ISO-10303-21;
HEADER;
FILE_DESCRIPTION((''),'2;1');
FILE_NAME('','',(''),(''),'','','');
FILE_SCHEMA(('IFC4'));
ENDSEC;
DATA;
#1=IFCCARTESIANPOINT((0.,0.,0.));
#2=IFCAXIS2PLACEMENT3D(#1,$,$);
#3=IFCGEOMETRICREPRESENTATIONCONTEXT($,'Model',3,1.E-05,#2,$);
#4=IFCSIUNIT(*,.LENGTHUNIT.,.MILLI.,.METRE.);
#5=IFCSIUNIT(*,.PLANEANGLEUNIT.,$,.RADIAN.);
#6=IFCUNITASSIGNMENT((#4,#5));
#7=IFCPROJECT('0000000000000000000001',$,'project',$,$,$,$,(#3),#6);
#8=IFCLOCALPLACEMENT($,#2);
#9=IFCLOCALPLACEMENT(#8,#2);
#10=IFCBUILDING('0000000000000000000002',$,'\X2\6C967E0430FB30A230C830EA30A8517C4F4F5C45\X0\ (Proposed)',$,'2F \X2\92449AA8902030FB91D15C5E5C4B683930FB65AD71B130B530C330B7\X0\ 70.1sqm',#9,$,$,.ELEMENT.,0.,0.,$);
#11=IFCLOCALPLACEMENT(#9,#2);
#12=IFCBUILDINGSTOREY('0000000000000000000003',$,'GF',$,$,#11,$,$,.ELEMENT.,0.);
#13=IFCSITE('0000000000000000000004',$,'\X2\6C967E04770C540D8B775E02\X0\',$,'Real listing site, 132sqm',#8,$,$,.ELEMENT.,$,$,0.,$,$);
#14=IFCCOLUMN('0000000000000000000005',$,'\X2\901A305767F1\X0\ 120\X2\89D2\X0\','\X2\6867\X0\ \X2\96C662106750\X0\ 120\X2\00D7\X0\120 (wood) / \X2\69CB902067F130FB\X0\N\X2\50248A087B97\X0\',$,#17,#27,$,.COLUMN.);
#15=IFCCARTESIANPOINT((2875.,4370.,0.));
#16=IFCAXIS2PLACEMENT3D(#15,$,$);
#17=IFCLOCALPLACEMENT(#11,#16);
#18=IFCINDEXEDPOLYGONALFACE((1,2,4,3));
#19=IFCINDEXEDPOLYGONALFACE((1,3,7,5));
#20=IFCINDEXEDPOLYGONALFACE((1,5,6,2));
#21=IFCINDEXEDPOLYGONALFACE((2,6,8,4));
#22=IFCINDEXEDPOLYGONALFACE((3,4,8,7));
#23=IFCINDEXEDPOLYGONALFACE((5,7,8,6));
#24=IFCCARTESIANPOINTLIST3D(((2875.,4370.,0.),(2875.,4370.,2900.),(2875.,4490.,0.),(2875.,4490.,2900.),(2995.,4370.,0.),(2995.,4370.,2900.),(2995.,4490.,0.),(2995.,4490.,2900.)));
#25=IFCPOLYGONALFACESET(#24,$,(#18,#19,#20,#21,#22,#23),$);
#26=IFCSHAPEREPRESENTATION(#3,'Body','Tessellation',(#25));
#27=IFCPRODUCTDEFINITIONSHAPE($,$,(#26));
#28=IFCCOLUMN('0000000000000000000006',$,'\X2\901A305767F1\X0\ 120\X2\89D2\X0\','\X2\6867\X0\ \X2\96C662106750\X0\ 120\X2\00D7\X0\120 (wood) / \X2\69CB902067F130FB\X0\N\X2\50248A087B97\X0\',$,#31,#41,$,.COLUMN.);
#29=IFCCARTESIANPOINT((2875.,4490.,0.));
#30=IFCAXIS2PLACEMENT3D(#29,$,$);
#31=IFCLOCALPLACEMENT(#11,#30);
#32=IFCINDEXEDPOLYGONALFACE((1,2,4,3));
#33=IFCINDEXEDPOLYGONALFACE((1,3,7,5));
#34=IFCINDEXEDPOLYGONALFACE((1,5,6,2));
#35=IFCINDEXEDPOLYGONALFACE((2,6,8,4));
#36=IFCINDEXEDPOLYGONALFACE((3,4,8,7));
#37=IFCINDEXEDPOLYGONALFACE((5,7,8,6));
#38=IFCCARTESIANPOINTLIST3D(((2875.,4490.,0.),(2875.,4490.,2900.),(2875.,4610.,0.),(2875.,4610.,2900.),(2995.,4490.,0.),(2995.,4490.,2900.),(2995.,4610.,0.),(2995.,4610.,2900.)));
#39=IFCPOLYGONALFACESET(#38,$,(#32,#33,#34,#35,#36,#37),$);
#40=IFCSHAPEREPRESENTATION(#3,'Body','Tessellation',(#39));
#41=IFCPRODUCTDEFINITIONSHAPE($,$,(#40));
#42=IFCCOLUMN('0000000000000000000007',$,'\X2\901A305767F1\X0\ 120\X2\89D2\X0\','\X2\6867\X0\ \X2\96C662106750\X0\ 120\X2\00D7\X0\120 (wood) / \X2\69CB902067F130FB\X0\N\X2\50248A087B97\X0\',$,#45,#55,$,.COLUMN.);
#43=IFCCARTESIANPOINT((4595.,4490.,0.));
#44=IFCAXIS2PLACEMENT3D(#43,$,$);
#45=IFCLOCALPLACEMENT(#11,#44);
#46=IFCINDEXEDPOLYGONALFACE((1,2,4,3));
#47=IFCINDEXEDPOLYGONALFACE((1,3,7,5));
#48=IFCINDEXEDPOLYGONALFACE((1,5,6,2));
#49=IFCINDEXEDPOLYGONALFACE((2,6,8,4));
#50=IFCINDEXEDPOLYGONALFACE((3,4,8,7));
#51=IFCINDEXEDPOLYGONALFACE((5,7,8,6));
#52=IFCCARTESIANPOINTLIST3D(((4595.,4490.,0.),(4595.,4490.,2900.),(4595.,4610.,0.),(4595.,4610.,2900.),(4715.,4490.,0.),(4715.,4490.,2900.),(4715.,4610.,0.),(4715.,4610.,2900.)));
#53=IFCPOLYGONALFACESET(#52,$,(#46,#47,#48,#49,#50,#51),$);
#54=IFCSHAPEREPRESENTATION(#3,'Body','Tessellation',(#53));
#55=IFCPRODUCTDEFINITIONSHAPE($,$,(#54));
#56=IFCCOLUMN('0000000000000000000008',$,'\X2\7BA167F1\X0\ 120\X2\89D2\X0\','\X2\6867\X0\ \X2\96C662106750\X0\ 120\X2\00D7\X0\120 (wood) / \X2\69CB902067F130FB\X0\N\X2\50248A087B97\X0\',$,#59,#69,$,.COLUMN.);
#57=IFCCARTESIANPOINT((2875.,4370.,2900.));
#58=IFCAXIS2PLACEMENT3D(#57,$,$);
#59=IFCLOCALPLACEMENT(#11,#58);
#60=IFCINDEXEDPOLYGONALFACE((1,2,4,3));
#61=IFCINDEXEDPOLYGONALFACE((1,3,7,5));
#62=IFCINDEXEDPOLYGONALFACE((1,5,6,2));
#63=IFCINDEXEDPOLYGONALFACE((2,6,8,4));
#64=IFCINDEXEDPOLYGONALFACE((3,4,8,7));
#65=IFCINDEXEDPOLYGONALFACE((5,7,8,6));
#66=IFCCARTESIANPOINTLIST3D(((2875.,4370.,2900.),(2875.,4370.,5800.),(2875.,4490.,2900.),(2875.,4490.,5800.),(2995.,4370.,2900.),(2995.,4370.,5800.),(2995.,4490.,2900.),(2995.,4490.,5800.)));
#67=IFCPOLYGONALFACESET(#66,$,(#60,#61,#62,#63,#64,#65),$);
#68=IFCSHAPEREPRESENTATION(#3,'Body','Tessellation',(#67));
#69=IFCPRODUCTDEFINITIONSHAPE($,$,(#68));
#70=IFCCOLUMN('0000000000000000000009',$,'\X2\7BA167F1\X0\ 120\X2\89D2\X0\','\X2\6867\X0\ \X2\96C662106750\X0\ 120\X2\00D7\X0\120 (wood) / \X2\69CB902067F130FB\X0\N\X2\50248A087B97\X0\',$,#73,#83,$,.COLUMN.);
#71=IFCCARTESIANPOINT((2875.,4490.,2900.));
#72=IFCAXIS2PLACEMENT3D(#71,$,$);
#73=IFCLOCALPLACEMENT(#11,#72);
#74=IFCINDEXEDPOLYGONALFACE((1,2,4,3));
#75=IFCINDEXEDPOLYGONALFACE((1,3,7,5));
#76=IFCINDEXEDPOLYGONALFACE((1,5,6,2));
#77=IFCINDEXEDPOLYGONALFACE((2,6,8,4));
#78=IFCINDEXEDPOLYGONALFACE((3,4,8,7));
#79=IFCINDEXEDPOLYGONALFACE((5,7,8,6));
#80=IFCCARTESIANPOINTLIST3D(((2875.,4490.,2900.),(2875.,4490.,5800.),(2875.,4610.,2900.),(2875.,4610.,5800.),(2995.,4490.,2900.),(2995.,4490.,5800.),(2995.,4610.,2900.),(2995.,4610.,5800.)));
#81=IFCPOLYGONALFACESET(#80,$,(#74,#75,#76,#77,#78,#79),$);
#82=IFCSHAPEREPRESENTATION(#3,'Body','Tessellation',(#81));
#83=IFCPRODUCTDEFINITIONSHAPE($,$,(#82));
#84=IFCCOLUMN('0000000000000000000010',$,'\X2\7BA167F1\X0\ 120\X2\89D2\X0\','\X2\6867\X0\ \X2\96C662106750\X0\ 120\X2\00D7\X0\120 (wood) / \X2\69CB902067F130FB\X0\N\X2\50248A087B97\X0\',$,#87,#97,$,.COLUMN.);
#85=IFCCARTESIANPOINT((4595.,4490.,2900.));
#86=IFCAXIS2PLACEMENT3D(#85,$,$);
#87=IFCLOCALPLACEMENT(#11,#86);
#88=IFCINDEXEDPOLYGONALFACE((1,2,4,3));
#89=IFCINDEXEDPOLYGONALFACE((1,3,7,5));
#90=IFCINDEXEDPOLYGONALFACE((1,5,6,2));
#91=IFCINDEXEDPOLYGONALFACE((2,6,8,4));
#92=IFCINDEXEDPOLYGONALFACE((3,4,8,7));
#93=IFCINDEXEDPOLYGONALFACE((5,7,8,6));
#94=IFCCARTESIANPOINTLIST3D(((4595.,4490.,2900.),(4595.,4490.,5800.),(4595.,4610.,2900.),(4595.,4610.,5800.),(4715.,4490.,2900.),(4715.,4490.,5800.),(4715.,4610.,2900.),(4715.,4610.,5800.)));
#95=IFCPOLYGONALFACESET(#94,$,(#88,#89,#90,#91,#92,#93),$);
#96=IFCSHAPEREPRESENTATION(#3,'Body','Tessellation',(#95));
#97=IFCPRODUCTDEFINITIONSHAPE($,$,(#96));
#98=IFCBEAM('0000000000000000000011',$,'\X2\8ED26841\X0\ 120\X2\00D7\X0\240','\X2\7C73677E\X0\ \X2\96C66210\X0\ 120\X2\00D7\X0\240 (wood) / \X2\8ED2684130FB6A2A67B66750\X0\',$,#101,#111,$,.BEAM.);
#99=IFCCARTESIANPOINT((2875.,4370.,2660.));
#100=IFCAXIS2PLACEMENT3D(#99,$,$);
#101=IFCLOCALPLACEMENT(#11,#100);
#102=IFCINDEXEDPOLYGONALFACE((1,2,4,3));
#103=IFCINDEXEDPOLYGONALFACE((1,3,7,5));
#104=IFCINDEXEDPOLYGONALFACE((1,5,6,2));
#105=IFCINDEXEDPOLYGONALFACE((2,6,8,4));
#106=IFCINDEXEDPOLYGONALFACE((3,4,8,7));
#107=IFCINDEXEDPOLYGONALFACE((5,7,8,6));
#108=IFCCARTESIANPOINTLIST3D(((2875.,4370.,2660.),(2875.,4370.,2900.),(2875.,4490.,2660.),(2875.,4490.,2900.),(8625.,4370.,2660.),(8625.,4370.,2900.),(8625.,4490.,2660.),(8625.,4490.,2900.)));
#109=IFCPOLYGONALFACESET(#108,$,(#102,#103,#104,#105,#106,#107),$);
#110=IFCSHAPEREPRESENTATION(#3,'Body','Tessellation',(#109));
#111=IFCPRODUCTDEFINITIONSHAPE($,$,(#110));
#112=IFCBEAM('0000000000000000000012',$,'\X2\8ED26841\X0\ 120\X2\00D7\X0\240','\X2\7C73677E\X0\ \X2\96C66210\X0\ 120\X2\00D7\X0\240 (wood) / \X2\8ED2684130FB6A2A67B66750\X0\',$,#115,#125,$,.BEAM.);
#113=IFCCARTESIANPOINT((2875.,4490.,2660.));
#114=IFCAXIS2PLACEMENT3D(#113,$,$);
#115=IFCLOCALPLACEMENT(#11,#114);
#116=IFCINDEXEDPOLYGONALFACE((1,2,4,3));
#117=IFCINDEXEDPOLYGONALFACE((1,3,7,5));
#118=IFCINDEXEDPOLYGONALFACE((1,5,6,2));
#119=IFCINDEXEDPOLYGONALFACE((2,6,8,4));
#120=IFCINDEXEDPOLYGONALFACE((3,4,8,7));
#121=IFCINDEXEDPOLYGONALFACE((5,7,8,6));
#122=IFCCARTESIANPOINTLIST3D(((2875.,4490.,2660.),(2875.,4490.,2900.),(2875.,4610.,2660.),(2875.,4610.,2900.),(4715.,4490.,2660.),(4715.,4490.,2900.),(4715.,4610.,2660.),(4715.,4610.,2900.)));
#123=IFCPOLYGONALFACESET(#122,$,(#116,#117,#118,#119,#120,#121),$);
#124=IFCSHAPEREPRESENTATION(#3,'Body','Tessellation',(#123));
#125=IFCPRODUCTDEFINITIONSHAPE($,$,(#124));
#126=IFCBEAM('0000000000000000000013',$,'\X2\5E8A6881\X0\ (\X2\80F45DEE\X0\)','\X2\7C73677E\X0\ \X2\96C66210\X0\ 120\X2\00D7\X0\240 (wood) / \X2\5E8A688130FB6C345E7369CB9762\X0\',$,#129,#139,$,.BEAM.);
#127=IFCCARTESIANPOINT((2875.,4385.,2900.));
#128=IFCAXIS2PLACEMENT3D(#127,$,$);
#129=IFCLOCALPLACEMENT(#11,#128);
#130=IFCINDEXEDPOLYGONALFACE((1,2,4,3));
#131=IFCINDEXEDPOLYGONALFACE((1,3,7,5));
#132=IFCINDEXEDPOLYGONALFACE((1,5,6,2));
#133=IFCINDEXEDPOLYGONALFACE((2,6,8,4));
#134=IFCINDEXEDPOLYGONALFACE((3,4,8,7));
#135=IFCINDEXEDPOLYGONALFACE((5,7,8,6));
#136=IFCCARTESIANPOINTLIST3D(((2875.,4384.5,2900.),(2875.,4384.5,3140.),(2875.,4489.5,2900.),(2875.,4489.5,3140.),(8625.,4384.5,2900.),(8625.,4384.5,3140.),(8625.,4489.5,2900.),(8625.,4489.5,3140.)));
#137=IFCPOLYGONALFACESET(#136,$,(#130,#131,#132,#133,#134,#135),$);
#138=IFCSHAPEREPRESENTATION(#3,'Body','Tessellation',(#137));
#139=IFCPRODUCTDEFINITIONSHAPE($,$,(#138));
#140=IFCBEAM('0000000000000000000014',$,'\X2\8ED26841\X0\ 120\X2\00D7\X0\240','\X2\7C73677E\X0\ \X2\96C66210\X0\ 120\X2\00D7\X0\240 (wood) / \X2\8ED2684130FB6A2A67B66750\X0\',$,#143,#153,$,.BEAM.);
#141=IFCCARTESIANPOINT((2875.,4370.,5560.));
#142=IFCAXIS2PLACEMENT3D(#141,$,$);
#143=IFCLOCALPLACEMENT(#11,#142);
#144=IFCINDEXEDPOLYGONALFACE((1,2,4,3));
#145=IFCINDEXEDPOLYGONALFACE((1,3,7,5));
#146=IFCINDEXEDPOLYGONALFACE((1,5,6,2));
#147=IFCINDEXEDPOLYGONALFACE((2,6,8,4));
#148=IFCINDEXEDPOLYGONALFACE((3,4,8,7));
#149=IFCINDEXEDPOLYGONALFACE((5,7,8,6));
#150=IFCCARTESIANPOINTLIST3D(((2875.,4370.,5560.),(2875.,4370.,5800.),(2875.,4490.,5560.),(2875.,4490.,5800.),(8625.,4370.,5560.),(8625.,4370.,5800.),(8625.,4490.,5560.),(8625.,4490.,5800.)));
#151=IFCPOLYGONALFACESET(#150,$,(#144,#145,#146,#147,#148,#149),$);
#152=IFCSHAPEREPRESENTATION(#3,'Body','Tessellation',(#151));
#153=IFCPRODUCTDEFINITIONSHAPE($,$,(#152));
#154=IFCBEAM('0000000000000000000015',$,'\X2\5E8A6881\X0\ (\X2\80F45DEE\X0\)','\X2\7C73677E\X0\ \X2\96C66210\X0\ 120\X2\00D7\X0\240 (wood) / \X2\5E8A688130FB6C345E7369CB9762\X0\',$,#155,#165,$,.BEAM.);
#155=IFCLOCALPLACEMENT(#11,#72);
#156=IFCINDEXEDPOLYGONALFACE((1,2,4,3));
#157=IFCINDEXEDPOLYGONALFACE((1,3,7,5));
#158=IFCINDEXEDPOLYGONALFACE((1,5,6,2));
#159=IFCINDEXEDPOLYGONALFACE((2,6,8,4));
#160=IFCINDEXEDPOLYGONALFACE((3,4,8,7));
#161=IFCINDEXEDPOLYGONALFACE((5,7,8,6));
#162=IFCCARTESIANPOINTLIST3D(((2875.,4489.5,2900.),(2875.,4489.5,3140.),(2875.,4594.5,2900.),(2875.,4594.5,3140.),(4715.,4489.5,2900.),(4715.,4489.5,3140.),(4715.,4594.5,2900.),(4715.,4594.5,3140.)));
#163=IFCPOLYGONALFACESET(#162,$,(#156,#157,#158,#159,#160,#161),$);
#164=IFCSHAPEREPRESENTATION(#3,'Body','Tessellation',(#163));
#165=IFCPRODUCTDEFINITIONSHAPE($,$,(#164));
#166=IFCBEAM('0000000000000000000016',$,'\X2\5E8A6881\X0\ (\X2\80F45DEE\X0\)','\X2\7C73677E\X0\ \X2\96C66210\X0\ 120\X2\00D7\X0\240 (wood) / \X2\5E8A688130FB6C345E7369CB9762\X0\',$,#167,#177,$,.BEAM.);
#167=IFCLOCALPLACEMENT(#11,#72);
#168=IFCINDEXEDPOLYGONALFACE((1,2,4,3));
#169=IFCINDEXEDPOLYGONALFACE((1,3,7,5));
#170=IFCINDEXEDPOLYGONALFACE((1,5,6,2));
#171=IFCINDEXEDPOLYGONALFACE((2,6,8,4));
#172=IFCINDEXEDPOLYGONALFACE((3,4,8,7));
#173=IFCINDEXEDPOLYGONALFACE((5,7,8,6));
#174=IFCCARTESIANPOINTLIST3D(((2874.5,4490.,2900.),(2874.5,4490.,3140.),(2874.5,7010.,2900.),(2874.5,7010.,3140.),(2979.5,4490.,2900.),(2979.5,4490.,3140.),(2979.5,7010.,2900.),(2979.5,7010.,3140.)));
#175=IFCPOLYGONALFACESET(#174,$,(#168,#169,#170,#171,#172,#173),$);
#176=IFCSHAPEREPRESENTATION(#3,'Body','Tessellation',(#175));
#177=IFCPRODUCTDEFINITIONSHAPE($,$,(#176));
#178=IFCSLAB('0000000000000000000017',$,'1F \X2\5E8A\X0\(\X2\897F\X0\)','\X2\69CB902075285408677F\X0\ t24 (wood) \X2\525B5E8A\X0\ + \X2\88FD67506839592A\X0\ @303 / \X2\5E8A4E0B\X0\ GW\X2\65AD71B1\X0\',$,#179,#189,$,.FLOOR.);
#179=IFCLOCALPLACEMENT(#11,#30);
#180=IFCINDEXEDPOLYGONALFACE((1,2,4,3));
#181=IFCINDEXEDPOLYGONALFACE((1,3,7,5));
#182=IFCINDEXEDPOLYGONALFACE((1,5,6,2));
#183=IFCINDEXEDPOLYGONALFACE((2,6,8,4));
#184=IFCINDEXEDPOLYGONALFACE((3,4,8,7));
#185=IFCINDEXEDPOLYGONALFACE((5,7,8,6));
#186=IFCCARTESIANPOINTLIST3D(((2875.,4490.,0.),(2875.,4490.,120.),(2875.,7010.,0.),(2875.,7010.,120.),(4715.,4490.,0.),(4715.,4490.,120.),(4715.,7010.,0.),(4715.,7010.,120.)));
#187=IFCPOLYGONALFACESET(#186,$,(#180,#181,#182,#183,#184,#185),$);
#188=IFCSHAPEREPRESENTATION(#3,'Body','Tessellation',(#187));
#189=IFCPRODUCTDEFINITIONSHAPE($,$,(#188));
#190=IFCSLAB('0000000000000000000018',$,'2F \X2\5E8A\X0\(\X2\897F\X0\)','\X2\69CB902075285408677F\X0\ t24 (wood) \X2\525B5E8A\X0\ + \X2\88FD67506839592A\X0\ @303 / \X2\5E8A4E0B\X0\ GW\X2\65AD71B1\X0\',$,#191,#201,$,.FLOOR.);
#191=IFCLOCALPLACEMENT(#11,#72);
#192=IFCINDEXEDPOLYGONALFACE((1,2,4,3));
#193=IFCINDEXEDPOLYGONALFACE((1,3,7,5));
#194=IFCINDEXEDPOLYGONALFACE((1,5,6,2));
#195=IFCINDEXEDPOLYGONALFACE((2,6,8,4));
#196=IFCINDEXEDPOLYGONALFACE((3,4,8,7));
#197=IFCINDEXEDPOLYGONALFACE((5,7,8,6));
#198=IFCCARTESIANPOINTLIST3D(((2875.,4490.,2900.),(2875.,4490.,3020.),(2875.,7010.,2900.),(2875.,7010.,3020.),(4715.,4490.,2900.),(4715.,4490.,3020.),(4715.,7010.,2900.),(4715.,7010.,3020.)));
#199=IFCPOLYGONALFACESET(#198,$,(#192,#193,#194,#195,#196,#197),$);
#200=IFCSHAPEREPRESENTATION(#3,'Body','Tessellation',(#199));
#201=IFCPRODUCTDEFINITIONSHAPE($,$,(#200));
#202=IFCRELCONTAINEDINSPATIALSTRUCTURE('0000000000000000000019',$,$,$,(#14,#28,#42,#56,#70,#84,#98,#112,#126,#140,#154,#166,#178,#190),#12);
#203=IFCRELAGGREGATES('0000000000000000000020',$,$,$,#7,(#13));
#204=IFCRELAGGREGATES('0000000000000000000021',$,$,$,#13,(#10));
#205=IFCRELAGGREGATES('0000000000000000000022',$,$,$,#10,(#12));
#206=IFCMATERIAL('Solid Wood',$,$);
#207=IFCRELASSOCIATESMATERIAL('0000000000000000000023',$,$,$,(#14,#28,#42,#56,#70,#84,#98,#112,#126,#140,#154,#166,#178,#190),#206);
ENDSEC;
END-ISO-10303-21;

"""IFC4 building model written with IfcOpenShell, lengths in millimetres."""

from ifc_helpers import new_model, si_unit, frame, frame_2d, origin, place, context, project, spatial, rectangle, extrude, material, element, save


model = new_model("IFC4")

# Units and contexts
model_context = context("Model", 3, precision=1e-05, world=origin())
ifc_project = project(units=[si_unit("LENGTHUNIT", "METRE", prefix="MILLI"), si_unit("PLANEANGLEUNIT", "RADIAN")], contexts=[model_context])

# Site, building, storey
site_placement = place(None, origin())
site = spatial("IfcSite", under=ifc_project, at=site_placement, Name="沖縄県名護市", ObjectType="Real listing site, 132sqm", CompositionType="ELEMENT", RefElevation=0.0)
building_placement = place(site_placement, origin())
building = spatial("IfcBuilding", under=site, at=building_placement, Name="沖縄・アトリエ兼住居 (Proposed)", ObjectType="2F 鉄骨造・金属屋根・断熱サッシ 70.1sqm", CompositionType="ELEMENT", ElevationOfRefHeight=0.0, ElevationOfTerrain=0.0)
storey_placement = place(building_placement, origin())
storey = spatial("IfcBuildingStorey", under=building, at=storey_placement, Name="GF", CompositionType="ELEMENT", Elevation=0.0)

# Columns
ifc_material_1 = material(Name="Solid Wood")
column_1_placement = place(storey_placement, frame((2875.0, 4370.0, 0.0)))
element("IfcColumn", 1, at=column_1_placement, inside=storey, material=ifc_material_1, Name="通し柱 120角", Description="桧 集成材 120×120 (wood) / 構造柱・N値計算", PredefinedType="COLUMN", context=model_context, shape_type="SweptSolid", body=[
    extrude(rectangle(XDim=120.0, YDim=120.0, at=frame_2d((60.0, 60.0))), frame((2875.0, 4370.0, 0.0)), (0.0, 0.0, 1.0), 2900.0),
])
column_2_placement = place(storey_placement, frame((2875.0, 4490.0, 0.0)))
element("IfcColumn", 2, at=column_2_placement, inside=storey, material=ifc_material_1, Name="通し柱 120角", Description="桧 集成材 120×120 (wood) / 構造柱・N値計算", PredefinedType="COLUMN", context=model_context, shape_type="SweptSolid", body=[
    extrude(rectangle(XDim=120.0, YDim=120.0, at=frame_2d((60.0, 60.0))), frame((2875.0, 4490.0, 0.0)), (0.0, 0.0, 1.0), 2900.0),
])
column_3_placement = place(storey_placement, frame((4595.0, 4490.0, 0.0)))
element("IfcColumn", 3, at=column_3_placement, inside=storey, material=ifc_material_1, Name="通し柱 120角", Description="桧 集成材 120×120 (wood) / 構造柱・N値計算", PredefinedType="COLUMN", context=model_context, shape_type="SweptSolid", body=[
    extrude(rectangle(XDim=120.0, YDim=120.0, at=frame_2d((60.0, 60.0))), frame((4595.0, 4490.0, 0.0)), (0.0, 0.0, 1.0), 2900.0),
])
column_4_placement = place(storey_placement, frame((2875.0, 4370.0, 2900.0)))
element("IfcColumn", 4, at=column_4_placement, inside=storey, material=ifc_material_1, Name="管柱 120角", Description="桧 集成材 120×120 (wood) / 構造柱・N値計算", PredefinedType="COLUMN", context=model_context, shape_type="SweptSolid", body=[
    extrude(rectangle(XDim=120.0, YDim=120.0, at=frame_2d((60.0, 60.0))), frame((2875.0, 4370.0, 2900.0)), (0.0, 0.0, 1.0), 2900.0),
])
column_5_placement = place(storey_placement, frame((2875.0, 4490.0, 2900.0)))
element("IfcColumn", 5, at=column_5_placement, inside=storey, material=ifc_material_1, Name="管柱 120角", Description="桧 集成材 120×120 (wood) / 構造柱・N値計算", PredefinedType="COLUMN", context=model_context, shape_type="SweptSolid", body=[
    extrude(rectangle(XDim=120.0, YDim=120.0, at=frame_2d((60.0, 60.0))), frame((2875.0, 4490.0, 2900.0)), (0.0, 0.0, 1.0), 2900.0),
])
column_6_placement = place(storey_placement, frame((4595.0, 4490.0, 2900.0)))
element("IfcColumn", 6, at=column_6_placement, inside=storey, material=ifc_material_1, Name="管柱 120角", Description="桧 集成材 120×120 (wood) / 構造柱・N値計算", PredefinedType="COLUMN", context=model_context, shape_type="SweptSolid", body=[
    extrude(rectangle(XDim=120.0, YDim=120.0, at=frame_2d((60.0, 60.0))), frame((4595.0, 4490.0, 2900.0)), (0.0, 0.0, 1.0), 2900.0),
])

# Beams
beam_1_placement = place(storey_placement, frame((2875.0, 4370.0, 2660.0)))
element("IfcBeam", 7, at=beam_1_placement, inside=storey, material=ifc_material_1, Name="軒桁 120×240", Description="米松 集成 120×240 (wood) / 軒桁・横架材", PredefinedType="BEAM", context=model_context, shape_type="SweptSolid", body=[
    extrude(rectangle(XDim=5750.0, YDim=120.0, at=frame_2d((2875.0, 60.0))), frame((2875.0, 4370.0, 2660.0)), (0.0, 0.0, 1.0), 240.0),
])
beam_2_placement = place(storey_placement, frame((2875.0, 4490.0, 2660.0)))
element("IfcBeam", 8, at=beam_2_placement, inside=storey, material=ifc_material_1, Name="軒桁 120×240", Description="米松 集成 120×240 (wood) / 軒桁・横架材", PredefinedType="BEAM", context=model_context, shape_type="SweptSolid", body=[
    extrude(rectangle(XDim=1840.0, YDim=120.0, at=frame_2d((920.0, 60.0))), frame((2875.0, 4490.0, 2660.0)), (0.0, 0.0, 1.0), 240.0),
])
beam_3_placement = place(storey_placement, frame((2875.0, 4385.0, 2900.0)))
element("IfcBeam", 9, at=beam_3_placement, inside=storey, material=ifc_material_1, Name="床梁 (胴差)", Description="米松 集成 120×240 (wood) / 床梁・水平構面", PredefinedType="BEAM", context=model_context, shape_type="SweptSolid", body=[
    extrude(rectangle(XDim=5750.0, YDim=105.0, at=frame_2d((2875.0, 52.0))), frame((2875.0, 4385.0, 2900.0)), (0.0, 0.0, 1.0), 240.0),
])
beam_4_placement = place(storey_placement, frame((2875.0, 4370.0, 5560.0)))
element("IfcBeam", 10, at=beam_4_placement, inside=storey, material=ifc_material_1, Name="軒桁 120×240", Description="米松 集成 120×240 (wood) / 軒桁・横架材", PredefinedType="BEAM", context=model_context, shape_type="SweptSolid", body=[
    extrude(rectangle(XDim=5750.0, YDim=120.0, at=frame_2d((2875.0, 60.0))), frame((2875.0, 4370.0, 5560.0)), (0.0, 0.0, 1.0), 240.0),
])
beam_5_placement = place(storey_placement, frame((2875.0, 4490.0, 2900.0)))
element("IfcBeam", 11, at=beam_5_placement, inside=storey, material=ifc_material_1, Name="床梁 (胴差)", Description="米松 集成 120×240 (wood) / 床梁・水平構面", PredefinedType="BEAM", context=model_context, shape_type="SweptSolid", body=[
    extrude(rectangle(XDim=1840.0, YDim=105.0, at=frame_2d((920.0, 52.0))), frame((2875.0, 4490.0, 2900.0)), (0.0, 0.0, 1.0), 240.0),
])
beam_6_placement = place(storey_placement, frame((2875.0, 4490.0, 2900.0)))
element("IfcBeam", 12, at=beam_6_placement, inside=storey, material=ifc_material_1, Name="床梁 (胴差)", Description="米松 集成 120×240 (wood) / 床梁・水平構面", PredefinedType="BEAM", context=model_context, shape_type="SweptSolid", body=[
    extrude(rectangle(XDim=105.0, YDim=2520.0, at=frame_2d((52.0, 1260.0))), frame((2875.0, 4490.0, 2900.0)), (0.0, 0.0, 1.0), 240.0),
])

# Slabs
slab_1_placement = place(storey_placement, frame((2875.0, 4490.0, 0.0)))
element("IfcSlab", 13, at=slab_1_placement, inside=storey, material=ifc_material_1, Name="1F 床(西)", Description="構造用合板 t24 (wood) 剛床 + 製材根太 @303 / 床下 GW断熱", PredefinedType="FLOOR", context=model_context, shape_type="SweptSolid", body=[
    extrude(rectangle(XDim=1840.0, YDim=2520.0, at=frame_2d((920.0, 1260.0))), frame((2875.0, 4490.0, 0.0)), (0.0, 0.0, 1.0), 120.0),
])
slab_2_placement = place(storey_placement, frame((2875.0, 4490.0, 2900.0)))
element("IfcSlab", 14, at=slab_2_placement, inside=storey, material=ifc_material_1, Name="2F 床(西)", Description="構造用合板 t24 (wood) 剛床 + 製材根太 @303 / 床下 GW断熱", PredefinedType="FLOOR", context=model_context, shape_type="SweptSolid", body=[
    extrude(rectangle(XDim=1840.0, YDim=2520.0, at=frame_2d((920.0, 1260.0))), frame((2875.0, 4490.0, 2900.0)), (0.0, 0.0, 1.0), 120.0),
])

save(model, "model.ifc")
